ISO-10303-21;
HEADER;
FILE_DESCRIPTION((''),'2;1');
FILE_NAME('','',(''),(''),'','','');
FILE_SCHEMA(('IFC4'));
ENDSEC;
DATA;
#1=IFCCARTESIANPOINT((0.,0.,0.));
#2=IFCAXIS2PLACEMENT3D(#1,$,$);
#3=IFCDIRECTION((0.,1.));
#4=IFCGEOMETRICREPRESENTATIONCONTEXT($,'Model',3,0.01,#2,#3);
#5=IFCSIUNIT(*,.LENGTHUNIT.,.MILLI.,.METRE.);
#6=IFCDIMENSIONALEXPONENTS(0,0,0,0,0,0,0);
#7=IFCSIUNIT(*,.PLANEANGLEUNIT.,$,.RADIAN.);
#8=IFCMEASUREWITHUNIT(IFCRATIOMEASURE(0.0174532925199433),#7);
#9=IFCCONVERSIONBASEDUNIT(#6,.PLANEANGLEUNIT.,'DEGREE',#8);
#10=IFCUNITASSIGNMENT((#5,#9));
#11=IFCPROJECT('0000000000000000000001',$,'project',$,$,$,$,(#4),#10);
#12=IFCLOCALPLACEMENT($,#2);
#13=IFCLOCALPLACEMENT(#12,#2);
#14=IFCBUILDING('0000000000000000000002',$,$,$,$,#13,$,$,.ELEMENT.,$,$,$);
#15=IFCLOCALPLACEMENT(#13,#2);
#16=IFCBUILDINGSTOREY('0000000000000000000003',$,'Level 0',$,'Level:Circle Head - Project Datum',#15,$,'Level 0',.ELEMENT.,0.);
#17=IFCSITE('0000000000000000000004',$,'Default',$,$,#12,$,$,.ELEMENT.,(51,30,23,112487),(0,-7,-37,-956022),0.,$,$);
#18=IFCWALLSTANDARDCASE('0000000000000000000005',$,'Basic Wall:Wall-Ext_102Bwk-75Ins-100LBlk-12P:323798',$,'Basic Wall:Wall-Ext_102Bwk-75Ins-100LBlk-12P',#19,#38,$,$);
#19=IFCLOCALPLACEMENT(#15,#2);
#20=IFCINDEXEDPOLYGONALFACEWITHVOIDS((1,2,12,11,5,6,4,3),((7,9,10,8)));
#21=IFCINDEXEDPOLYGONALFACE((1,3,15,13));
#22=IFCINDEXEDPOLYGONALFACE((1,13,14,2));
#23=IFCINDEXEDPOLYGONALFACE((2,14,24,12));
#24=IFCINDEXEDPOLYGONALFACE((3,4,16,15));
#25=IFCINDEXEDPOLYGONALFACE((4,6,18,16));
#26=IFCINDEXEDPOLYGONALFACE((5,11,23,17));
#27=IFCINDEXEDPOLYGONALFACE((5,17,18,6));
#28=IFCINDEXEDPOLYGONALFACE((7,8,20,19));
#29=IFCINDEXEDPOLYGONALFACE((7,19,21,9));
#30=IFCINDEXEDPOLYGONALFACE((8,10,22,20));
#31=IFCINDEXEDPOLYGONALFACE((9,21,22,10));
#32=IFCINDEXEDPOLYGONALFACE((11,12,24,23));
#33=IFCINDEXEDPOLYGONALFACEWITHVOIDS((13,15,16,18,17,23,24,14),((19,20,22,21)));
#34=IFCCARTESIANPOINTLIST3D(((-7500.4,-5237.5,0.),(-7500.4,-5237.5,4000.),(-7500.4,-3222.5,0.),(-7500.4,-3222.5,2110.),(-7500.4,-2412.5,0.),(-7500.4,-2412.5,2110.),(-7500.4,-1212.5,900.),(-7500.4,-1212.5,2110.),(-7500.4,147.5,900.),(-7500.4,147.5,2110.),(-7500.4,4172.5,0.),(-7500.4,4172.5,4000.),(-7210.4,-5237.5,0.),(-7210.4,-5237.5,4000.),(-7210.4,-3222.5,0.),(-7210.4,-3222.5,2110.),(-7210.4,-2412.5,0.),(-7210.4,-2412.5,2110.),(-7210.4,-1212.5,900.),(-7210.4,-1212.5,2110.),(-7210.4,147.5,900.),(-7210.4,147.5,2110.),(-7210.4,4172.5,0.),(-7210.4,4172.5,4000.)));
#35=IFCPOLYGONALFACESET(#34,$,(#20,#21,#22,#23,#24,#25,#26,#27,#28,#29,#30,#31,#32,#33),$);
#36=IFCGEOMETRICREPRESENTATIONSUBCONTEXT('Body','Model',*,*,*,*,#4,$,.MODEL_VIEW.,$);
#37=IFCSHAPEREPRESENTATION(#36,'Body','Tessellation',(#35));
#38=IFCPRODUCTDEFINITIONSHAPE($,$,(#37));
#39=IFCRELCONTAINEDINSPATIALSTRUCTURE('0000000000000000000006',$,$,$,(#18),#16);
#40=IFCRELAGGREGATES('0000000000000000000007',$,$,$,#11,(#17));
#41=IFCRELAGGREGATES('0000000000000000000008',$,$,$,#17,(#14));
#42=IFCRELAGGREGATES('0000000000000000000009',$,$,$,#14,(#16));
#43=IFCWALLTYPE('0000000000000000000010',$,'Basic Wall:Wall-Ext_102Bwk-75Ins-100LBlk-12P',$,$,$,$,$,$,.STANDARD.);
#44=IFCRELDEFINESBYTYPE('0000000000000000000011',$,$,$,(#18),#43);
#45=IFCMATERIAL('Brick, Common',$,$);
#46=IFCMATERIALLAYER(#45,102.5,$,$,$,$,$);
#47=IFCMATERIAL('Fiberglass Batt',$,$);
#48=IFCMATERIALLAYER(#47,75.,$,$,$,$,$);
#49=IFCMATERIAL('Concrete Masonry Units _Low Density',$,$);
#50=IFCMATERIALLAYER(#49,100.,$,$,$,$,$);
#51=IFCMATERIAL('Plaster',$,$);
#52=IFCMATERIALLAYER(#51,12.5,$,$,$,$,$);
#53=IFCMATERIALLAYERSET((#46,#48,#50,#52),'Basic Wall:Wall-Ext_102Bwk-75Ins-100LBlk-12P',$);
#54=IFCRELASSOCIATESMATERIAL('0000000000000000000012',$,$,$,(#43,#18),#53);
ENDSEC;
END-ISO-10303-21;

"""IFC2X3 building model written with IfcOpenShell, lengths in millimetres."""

from ifc_helpers import new_model, entity, si_unit, converted_unit, direction, frame, frame_2d, origin, place, context, subcontext, project, spatial, rectangle, extrude, material, layer, layer_set, layer_usage, type_object, element, save


model = new_model("IFC2X3")

# Units and contexts
model_context = context("Model", 3, precision=0.01, world=origin(), true_north=direction((0.0, 1.0)))
body_context = subcontext(model_context, "Body", "Model", "MODEL_VIEW")
ifc_project = project(units=[si_unit("LENGTHUNIT", "METRE", prefix="MILLI"), converted_unit("PLANEANGLEUNIT", "DEGREE", entity("IfcRatioMeasure", 0.0174532925199433), si_unit("PLANEANGLEUNIT", "RADIAN"), dimensions=[0, 0, 0, 0, 0, 0, 0])], contexts=[model_context])

# Site, building, storey
site_placement = place(None, origin())
site = spatial("IfcSite", under=ifc_project, at=site_placement, Name="Default", CompositionType="ELEMENT", RefLatitude=(51, 30, 23, 112487), RefLongitude=(0, -7, -37, -956022), RefElevation=0.0)
building_placement = place(site_placement, origin())
building = spatial("IfcBuilding", under=site, at=building_placement, CompositionType="ELEMENT")
storey_placement = place(building_placement, origin())
storey = spatial("IfcBuildingStorey", under=building, at=storey_placement, Name="Level 0", ObjectType="Level:Circle Head - Project Datum", LongName="Level 0", CompositionType="ELEMENT", Elevation=0.0)

# Shared definitions
ifc_material_1 = material(Name="Brick, Common")
ifc_layer_1 = layer(ifc_material_1, 102.5)
ifc_material_2 = material(Name="Fiberglass Batt")
ifc_layer_2 = layer(ifc_material_2, 75.0)
ifc_material_3 = material(Name="Concrete Masonry Units _Low Density")
ifc_layer_3 = layer(ifc_material_3, 100.0)
ifc_material_4 = material(Name="Plaster")
ifc_layer_4 = layer(ifc_material_4, 12.5)
ifc_layer_set_1 = layer_set([ifc_layer_1, ifc_layer_2, ifc_layer_3, ifc_layer_4], Name="Basic Wall:Wall-Ext_102Bwk-75Ins-100LBlk-12P")
wall_type = type_object("IfcWallType", Name="Basic Wall:Wall-Ext_102Bwk-75Ins-100LBlk-12P", PredefinedType="STANDARD", material=ifc_layer_set_1)

# Wall, openings
ifc_layer_usage_1 = layer_usage(ifc_layer_set_1, "AXIS2", "NEGATIVE", 145.0)
wall_1_placement = place(storey_placement, frame((-7355.4, -5237.5, 0.0), z_axis=(0.0, 0.0, 1.0), x_axis=(0.0, 1.0, 0.0)))
wall_1 = element("IfcWallStandardCase", 1, at=wall_1_placement, inside=storey, type_object=wall_type, material=ifc_layer_usage_1, Name="Basic Wall:Wall-Ext_102Bwk-75Ins-100LBlk-12P:323798", ObjectType="Basic Wall:Wall-Ext_102Bwk-75Ins-100LBlk-12P", context=body_context, shape_type="SweptSolid", body=[
    extrude(rectangle(XDim=9410.0, YDim=290.0, at=frame_2d((4705.0, 0.0), x_axis=(-1.0, 0.0))), origin(), (0.0, 0.0, 1.0), 4000.0),
])
opening_1_placement = place(wall_1_placement, frame((2825.0, 145.0, 0.0)))
element("IfcOpeningElement", 2, at=opening_1_placement, cuts=wall_1, ObjectType="Opening", context=body_context, shape_type="SweptSolid", body=[
    extrude(rectangle(XDim=2110.0, YDim=810.0, at=frame_2d((1055.0, 405.0), x_axis=(1.0, 0.0))), frame((0.0, 0.0, 0.0), z_axis=(0.0, -1.0, 0.0), x_axis=(0.0, 0.0, 1.0)), (0.0, 0.0, 1.0), 290.0),
])
opening_2_placement = place(wall_1_placement, frame((5385.0, 145.0, 900.0)))
element("IfcOpeningElement", 3, at=opening_2_placement, cuts=wall_1, ObjectType="Opening", context=body_context, shape_type="SweptSolid", body=[
    extrude(rectangle(XDim=1210.0, YDim=1360.0, at=frame_2d((605.0, 680.0), x_axis=(-1.0, 0.0))), frame((0.0, 0.0, 0.0), z_axis=(0.0, -1.0, 0.0), x_axis=(0.0, 0.0, 1.0)), (0.0, 0.0, 1.0), 290.0),
])

save(model, "model.ifc")
